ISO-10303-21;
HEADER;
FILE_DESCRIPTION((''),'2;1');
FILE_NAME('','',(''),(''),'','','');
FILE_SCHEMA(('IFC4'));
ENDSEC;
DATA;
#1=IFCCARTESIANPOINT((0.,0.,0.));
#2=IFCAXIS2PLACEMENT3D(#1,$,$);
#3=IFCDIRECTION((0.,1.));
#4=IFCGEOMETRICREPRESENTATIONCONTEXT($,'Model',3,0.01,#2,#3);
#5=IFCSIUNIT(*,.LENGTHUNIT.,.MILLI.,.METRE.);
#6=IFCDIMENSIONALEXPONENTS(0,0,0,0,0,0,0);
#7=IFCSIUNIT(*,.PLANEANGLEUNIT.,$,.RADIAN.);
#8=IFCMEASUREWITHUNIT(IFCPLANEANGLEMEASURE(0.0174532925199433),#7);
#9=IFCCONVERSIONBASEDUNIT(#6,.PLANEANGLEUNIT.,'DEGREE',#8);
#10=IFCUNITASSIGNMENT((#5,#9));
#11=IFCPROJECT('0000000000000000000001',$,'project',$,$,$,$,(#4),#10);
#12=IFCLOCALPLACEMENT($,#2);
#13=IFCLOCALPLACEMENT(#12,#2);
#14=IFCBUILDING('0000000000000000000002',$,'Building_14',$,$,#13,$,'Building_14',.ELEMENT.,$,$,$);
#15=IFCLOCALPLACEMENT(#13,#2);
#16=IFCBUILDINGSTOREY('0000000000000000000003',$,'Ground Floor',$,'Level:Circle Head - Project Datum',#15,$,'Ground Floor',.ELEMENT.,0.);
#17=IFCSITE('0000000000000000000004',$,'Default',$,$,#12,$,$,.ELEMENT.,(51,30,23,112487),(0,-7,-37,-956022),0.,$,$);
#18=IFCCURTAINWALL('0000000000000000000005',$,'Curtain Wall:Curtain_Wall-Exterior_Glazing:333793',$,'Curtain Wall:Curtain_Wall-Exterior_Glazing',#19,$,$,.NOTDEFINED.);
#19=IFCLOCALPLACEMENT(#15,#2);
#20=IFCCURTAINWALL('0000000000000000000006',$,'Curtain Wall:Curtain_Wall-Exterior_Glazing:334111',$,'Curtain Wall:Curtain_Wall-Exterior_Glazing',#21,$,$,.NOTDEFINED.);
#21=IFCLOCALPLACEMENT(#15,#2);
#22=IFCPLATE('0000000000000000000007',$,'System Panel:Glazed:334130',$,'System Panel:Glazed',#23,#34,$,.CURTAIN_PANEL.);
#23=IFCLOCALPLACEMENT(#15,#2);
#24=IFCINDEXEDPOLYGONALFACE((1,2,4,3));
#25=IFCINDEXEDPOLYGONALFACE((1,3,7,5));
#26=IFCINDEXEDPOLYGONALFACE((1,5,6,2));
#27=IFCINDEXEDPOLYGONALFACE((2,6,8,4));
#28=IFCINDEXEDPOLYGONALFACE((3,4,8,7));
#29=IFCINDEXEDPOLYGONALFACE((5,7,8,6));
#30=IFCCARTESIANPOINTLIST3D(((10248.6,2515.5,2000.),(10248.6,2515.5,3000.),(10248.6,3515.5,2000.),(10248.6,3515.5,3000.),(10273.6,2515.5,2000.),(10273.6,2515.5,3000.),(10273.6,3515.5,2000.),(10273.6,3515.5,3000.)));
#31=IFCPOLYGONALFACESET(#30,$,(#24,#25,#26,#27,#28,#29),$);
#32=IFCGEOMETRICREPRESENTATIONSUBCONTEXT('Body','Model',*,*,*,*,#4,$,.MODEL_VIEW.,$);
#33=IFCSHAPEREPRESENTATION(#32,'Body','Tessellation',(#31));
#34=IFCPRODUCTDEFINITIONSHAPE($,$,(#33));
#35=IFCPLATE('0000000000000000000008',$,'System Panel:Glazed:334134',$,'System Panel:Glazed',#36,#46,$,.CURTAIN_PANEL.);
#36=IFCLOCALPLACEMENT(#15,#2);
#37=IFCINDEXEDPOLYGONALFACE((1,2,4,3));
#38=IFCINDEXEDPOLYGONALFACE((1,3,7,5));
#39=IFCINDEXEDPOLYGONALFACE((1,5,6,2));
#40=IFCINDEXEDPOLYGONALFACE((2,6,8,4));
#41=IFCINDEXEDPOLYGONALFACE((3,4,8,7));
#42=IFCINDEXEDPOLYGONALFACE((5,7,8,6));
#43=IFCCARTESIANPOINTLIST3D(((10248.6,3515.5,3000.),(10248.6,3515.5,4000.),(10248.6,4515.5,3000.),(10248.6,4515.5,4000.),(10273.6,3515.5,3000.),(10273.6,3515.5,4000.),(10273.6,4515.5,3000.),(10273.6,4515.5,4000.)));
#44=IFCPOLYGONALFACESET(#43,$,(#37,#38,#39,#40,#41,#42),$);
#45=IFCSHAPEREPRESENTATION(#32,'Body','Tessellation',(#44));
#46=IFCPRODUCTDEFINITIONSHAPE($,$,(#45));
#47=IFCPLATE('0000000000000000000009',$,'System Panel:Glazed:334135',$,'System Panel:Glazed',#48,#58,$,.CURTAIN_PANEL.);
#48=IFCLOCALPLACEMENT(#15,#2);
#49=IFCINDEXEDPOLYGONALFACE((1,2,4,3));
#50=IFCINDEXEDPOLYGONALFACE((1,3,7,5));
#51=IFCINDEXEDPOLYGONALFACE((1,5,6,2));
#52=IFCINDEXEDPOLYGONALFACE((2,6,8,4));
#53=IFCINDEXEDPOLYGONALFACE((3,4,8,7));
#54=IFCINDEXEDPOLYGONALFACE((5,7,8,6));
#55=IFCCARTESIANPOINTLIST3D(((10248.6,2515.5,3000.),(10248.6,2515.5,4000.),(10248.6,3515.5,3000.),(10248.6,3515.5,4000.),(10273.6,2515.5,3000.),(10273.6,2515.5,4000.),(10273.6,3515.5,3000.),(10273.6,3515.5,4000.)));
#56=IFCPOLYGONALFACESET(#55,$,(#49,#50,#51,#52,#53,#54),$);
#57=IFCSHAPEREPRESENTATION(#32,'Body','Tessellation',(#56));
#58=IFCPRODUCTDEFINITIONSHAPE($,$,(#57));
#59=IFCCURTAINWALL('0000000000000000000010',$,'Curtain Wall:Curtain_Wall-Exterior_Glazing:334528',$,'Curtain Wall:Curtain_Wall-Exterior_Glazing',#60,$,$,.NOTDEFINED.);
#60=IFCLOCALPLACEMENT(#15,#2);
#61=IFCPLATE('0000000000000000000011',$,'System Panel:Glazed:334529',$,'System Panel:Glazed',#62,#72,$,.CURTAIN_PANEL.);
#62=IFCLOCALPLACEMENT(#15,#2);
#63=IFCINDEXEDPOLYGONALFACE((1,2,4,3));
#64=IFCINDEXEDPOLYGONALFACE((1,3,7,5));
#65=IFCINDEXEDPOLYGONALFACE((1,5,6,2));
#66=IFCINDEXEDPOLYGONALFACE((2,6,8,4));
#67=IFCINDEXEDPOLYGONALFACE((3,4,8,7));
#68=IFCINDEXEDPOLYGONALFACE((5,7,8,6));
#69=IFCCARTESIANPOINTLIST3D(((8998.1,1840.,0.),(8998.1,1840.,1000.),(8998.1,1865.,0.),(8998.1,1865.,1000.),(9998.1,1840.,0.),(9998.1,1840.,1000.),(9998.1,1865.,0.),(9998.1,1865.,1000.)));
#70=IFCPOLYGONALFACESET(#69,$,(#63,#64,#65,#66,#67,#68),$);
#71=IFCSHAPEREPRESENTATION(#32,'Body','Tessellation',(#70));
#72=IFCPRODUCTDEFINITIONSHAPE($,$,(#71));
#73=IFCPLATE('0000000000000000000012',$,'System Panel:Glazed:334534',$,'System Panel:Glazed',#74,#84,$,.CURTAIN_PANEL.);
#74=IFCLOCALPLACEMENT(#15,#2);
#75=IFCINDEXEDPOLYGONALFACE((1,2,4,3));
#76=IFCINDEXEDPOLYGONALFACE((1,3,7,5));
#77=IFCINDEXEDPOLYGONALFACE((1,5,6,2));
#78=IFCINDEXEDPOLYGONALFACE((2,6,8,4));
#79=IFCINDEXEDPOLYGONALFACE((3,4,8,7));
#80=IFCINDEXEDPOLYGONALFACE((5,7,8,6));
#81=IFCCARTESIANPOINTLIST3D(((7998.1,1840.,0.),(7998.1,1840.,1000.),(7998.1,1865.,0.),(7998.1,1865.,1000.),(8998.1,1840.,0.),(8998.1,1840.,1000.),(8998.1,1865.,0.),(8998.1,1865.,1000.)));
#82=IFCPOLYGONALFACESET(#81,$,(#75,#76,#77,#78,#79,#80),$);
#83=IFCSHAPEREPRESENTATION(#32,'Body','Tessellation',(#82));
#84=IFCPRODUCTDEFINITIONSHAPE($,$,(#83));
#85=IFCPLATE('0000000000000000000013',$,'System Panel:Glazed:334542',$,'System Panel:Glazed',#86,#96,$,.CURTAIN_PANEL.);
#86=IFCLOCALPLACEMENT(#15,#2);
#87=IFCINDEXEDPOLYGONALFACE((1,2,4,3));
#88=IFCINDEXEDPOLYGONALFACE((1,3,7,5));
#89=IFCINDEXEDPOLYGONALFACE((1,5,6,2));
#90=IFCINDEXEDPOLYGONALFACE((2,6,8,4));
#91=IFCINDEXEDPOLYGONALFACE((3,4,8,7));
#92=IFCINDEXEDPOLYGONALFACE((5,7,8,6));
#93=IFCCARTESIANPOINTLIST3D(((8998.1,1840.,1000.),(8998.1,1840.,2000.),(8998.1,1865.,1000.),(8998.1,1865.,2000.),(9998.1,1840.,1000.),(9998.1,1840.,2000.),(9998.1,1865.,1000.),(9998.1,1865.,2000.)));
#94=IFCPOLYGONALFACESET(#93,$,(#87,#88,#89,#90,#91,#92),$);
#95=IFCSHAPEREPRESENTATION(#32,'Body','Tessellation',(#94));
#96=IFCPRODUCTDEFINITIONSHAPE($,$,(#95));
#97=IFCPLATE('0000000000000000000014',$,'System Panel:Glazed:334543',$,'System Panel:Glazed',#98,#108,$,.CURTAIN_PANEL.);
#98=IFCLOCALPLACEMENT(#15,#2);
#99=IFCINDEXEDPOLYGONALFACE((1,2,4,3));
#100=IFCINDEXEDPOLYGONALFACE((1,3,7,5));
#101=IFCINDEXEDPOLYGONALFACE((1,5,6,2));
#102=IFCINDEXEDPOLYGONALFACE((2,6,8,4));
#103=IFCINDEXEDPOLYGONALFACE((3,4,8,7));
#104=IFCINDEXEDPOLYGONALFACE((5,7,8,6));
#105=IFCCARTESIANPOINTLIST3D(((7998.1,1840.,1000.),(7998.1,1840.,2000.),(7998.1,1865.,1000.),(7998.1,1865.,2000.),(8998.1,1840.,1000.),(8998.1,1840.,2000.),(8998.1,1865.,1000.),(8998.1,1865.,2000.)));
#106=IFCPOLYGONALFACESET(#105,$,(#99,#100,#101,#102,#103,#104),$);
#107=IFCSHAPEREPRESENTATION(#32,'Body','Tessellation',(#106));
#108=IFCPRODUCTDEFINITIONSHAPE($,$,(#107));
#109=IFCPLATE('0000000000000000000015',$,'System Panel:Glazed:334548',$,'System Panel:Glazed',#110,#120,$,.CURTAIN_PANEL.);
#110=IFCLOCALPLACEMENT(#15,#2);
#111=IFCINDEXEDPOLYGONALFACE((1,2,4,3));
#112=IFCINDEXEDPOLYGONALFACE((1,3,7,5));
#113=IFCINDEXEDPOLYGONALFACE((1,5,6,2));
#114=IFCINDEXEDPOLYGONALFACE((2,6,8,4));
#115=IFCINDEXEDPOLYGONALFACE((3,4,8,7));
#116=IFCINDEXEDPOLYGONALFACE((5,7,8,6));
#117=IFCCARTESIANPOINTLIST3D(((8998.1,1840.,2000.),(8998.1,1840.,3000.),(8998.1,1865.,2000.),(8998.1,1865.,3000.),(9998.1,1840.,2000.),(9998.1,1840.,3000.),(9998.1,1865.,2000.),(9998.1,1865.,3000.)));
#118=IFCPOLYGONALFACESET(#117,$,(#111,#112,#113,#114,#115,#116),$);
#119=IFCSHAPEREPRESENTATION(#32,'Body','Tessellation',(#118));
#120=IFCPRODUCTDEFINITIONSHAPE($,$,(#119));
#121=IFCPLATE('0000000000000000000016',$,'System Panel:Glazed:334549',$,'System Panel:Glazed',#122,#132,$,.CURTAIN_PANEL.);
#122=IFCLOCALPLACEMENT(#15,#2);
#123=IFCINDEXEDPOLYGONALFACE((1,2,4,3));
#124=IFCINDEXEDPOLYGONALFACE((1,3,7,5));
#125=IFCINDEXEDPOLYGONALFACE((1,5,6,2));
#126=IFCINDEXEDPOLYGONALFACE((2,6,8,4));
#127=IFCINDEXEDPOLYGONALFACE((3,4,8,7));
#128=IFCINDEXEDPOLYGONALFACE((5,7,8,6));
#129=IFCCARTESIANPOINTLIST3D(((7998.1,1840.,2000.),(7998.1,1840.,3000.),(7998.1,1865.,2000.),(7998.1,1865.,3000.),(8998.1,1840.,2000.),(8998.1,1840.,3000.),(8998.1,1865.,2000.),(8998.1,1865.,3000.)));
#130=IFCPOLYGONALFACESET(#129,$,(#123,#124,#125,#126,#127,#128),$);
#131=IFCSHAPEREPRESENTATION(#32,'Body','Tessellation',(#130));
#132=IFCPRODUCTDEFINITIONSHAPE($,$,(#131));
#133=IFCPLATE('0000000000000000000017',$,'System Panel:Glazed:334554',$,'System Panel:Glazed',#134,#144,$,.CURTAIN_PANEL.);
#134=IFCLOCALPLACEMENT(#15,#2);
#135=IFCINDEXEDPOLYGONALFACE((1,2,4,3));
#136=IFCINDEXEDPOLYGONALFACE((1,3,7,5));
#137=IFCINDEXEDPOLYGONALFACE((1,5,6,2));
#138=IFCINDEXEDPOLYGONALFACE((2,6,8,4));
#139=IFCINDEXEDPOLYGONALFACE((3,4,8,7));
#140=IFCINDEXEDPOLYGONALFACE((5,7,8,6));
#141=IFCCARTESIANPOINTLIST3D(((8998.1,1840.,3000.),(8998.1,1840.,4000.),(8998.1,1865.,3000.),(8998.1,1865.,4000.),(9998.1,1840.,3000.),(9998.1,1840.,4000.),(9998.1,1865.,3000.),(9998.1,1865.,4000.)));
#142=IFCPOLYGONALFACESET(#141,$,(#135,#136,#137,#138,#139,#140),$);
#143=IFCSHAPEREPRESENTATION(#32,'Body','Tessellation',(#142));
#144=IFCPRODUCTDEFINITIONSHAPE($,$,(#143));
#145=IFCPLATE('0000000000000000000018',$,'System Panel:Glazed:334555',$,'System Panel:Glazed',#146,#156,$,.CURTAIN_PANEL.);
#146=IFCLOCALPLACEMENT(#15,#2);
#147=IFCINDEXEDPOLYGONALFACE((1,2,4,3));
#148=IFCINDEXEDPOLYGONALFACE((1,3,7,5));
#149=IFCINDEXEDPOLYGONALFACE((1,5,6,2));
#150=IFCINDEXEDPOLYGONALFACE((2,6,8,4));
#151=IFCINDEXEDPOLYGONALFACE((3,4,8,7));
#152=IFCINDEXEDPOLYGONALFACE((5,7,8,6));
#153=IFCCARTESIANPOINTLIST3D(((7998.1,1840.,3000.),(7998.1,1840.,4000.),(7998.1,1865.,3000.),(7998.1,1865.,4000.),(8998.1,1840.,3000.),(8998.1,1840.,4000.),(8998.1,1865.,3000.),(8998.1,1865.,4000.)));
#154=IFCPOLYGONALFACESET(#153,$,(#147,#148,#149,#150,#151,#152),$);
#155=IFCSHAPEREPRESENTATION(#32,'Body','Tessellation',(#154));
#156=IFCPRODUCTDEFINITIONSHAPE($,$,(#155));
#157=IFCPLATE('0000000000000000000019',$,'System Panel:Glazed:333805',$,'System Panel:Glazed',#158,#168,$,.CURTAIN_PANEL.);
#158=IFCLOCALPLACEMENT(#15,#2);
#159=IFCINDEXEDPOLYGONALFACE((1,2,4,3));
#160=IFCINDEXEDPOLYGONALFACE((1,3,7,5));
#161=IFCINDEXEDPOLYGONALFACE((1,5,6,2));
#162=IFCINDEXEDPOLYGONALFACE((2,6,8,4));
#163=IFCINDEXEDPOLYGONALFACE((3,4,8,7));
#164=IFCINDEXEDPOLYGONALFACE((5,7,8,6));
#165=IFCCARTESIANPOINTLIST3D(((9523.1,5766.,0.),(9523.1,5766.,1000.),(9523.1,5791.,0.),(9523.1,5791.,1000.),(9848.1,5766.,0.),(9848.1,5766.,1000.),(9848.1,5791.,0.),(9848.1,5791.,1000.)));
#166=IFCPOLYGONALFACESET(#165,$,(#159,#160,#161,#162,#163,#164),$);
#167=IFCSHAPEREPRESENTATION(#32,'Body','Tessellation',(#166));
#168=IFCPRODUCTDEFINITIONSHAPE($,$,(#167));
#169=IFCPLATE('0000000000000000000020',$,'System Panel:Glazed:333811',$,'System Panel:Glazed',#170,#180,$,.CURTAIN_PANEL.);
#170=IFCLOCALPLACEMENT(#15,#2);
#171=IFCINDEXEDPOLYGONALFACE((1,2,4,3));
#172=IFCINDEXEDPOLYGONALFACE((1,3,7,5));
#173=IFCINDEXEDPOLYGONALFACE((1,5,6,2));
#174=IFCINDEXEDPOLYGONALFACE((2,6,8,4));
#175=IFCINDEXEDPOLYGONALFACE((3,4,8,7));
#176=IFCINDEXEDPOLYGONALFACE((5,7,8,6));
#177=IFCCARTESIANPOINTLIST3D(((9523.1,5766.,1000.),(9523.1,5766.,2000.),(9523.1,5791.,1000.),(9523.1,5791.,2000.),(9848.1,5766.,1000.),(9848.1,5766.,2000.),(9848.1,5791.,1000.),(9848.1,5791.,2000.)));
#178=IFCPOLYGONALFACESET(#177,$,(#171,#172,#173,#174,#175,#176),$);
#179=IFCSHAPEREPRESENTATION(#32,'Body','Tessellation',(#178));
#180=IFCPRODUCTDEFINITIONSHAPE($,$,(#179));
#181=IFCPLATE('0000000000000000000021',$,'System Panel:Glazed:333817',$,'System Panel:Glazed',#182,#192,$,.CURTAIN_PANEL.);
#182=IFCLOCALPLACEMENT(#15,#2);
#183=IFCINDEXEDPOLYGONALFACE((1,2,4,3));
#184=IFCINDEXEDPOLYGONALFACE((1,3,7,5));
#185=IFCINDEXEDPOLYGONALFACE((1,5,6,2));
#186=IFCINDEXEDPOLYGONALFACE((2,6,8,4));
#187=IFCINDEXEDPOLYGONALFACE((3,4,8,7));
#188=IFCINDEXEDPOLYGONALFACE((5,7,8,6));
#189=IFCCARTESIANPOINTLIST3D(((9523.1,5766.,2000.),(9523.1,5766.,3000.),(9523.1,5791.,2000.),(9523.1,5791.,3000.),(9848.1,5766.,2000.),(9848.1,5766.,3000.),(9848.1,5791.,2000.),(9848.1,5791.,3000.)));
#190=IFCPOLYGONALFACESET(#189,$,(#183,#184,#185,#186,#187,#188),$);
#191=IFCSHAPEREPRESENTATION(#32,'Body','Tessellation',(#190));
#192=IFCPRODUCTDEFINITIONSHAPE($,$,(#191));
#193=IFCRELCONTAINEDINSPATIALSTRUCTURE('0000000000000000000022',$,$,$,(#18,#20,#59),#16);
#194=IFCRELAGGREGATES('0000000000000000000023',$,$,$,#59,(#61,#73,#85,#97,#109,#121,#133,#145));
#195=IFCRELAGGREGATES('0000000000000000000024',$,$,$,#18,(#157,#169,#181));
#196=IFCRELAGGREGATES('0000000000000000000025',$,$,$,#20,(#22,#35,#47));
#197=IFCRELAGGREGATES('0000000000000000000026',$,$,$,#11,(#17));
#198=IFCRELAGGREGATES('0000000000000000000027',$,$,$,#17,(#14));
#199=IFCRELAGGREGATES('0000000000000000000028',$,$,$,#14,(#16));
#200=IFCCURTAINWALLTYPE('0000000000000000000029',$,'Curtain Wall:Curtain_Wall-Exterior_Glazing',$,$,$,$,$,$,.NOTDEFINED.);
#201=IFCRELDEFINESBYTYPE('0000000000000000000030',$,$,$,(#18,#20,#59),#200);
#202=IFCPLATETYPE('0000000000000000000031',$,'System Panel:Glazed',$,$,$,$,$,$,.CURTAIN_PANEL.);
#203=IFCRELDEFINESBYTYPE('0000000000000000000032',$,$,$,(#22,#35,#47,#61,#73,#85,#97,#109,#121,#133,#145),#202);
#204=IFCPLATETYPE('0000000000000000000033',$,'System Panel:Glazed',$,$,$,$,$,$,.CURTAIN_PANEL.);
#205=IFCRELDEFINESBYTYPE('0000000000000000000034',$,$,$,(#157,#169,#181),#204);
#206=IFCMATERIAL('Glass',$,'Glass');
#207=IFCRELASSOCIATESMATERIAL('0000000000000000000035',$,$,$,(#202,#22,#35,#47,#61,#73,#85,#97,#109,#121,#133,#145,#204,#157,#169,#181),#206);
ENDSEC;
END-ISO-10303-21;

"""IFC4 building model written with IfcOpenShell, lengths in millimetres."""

from ifc_helpers import new_model, entity, si_unit, converted_unit, direction, frame, origin, place, context, subcontext, project, spatial, indexed_curve, outline, extrude, source, transform, mapped, material, type_object, type_shapes, element, aggregate, save


model = new_model("IFC4")

# Units and contexts
model_context = context("Model", 3, precision=0.01, world=origin(), true_north=direction((0.0, 1.0)))
body_context = subcontext(model_context, "Body", "Model", "MODEL_VIEW")
ifc_project = project(units=[si_unit("LENGTHUNIT", "METRE", prefix="MILLI"), converted_unit("PLANEANGLEUNIT", "DEGREE", entity("IfcPlaneAngleMeasure", 0.0174532925199433), si_unit("PLANEANGLEUNIT", "RADIAN"), dimensions=[0, 0, 0, 0, 0, 0, 0])], contexts=[model_context])

# Site, building, storey
site_placement = place(None, origin())
site = spatial("IfcSite", under=ifc_project, at=site_placement, Name="Default", CompositionType="ELEMENT", RefLatitude=(51, 30, 23, 112487), RefLongitude=(0, -7, -37, -956022), RefElevation=0.0)
building_placement = place(site_placement, origin())
building = spatial("IfcBuilding", under=site, at=building_placement, Name="Building_14", LongName="Building_14", CompositionType="ELEMENT")
storey_placement = place(building_placement, origin())
storey = spatial("IfcBuildingStorey", under=building, at=storey_placement, Name="Ground Floor", ObjectType="Level:Circle Head - Project Datum", LongName="Ground Floor", CompositionType="ELEMENT", Elevation=0.0)

# Curtain walls, plates
curtain_wall_type = type_object("IfcCurtainWallType", Name="Curtain Wall:Curtain_Wall-Exterior_Glazing", PredefinedType="NOTDEFINED")
curtain_wall_1_placement = place(storey_placement, origin())
curtain_wall_1 = element("IfcCurtainWall", 1, at=curtain_wall_1_placement, inside=storey, type_object=curtain_wall_type, Name="Curtain Wall:Curtain_Wall-Exterior_Glazing:333793", ObjectType="Curtain Wall:Curtain_Wall-Exterior_Glazing", PredefinedType="NOTDEFINED")
ifc_material = material(Name="Glass", Category="Glass")
plate_type_1 = type_object("IfcPlateType", Name="System Panel:Glazed", PredefinedType="CURTAIN_PANEL", material=ifc_material)
shared_shape_1 = source(origin(), body_context, "Body", "SweptSolid", [
    extrude(outline(indexed_curve([(-12.5, -500.0), (12.5, -500.0), (12.5, 500.0), (-12.5, 500.0), (-12.5, -500.0)], self_intersect=False)), frame((0.0, -37.0, 0.0), z_axis=(0.0, 0.0, 1.0), x_axis=(0.0, 1.0, 0.0)), (0.0, 0.0, 1.0), 1000.0),
])
type_shapes(plate_type_1, [shared_shape_1])
curtain_wall_2_placement = place(storey_placement, origin())
curtain_wall_2 = element("IfcCurtainWall", 2, at=curtain_wall_2_placement, inside=storey, type_object=curtain_wall_type, Name="Curtain Wall:Curtain_Wall-Exterior_Glazing:334111", ObjectType="Curtain Wall:Curtain_Wall-Exterior_Glazing", PredefinedType="NOTDEFINED")
plate_1_placement = place(curtain_wall_2_placement, frame((10298.1, 3015.5, 2000.0), z_axis=(0.0, 0.0, 1.0), x_axis=(0.0, -1.0, 0.0)))
plate_1 = element("IfcPlate", 3, at=plate_1_placement, type_object=plate_type_1, material=ifc_material, Name="System Panel:Glazed:334130", ObjectType="System Panel:Glazed", PredefinedType="CURTAIN_PANEL", context=body_context, shape_type="MappedRepresentation", body=[
    mapped(shared_shape_1, transform((0.0, 0.0, 0.0), scale=1.0)),
])
plate_2_placement = place(curtain_wall_2_placement, frame((10298.1, 4015.5, 3000.0), z_axis=(0.0, 0.0, 1.0), x_axis=(0.0, -1.0, 0.0)))
plate_2 = element("IfcPlate", 4, at=plate_2_placement, type_object=plate_type_1, material=ifc_material, Name="System Panel:Glazed:334134", ObjectType="System Panel:Glazed", PredefinedType="CURTAIN_PANEL", context=body_context, shape_type="MappedRepresentation", body=[
    mapped(shared_shape_1, transform((0.0, 0.0, 0.0), scale=1.0)),
])
plate_3_placement = place(curtain_wall_2_placement, frame((10298.1, 3015.5, 3000.0), z_axis=(0.0, 0.0, 1.0), x_axis=(0.0, -1.0, 0.0)))
plate_3 = element("IfcPlate", 5, at=plate_3_placement, type_object=plate_type_1, material=ifc_material, Name="System Panel:Glazed:334135", ObjectType="System Panel:Glazed", PredefinedType="CURTAIN_PANEL", context=body_context, shape_type="MappedRepresentation", body=[
    mapped(shared_shape_1, transform((0.0, 0.0, 0.0), scale=1.0)),
])
curtain_wall_3_placement = place(storey_placement, origin())
curtain_wall_3 = element("IfcCurtainWall", 6, at=curtain_wall_3_placement, inside=storey, type_object=curtain_wall_type, Name="Curtain Wall:Curtain_Wall-Exterior_Glazing:334528", ObjectType="Curtain Wall:Curtain_Wall-Exterior_Glazing", PredefinedType="NOTDEFINED")
plate_4_placement = place(curtain_wall_3_placement, frame((9498.1, 1815.5, 0.0), z_axis=(0.0, 0.0, 1.0), x_axis=(-1.0, 0.0, 0.0)))
plate_4 = element("IfcPlate", 7, at=plate_4_placement, type_object=plate_type_1, material=ifc_material, Name="System Panel:Glazed:334529", ObjectType="System Panel:Glazed", PredefinedType="CURTAIN_PANEL", context=body_context, shape_type="MappedRepresentation", body=[
    mapped(shared_shape_1, transform((0.0, 0.0, 0.0), scale=1.0)),
])
plate_5_placement = place(curtain_wall_3_placement, frame((8498.1, 1815.5, 0.0), z_axis=(0.0, 0.0, 1.0), x_axis=(-1.0, 0.0, 0.0)))
plate_5 = element("IfcPlate", 8, at=plate_5_placement, type_object=plate_type_1, material=ifc_material, Name="System Panel:Glazed:334534", ObjectType="System Panel:Glazed", PredefinedType="CURTAIN_PANEL", context=body_context, shape_type="MappedRepresentation", body=[
    mapped(shared_shape_1, transform((0.0, 0.0, 0.0), scale=1.0)),
])
plate_6_placement = place(curtain_wall_3_placement, frame((9498.1, 1815.5, 1000.0), z_axis=(0.0, 0.0, 1.0), x_axis=(-1.0, 0.0, 0.0)))
plate_6 = element("IfcPlate", 9, at=plate_6_placement, type_object=plate_type_1, material=ifc_material, Name="System Panel:Glazed:334542", ObjectType="System Panel:Glazed", PredefinedType="CURTAIN_PANEL", context=body_context, shape_type="MappedRepresentation", body=[
    mapped(shared_shape_1, transform((0.0, 0.0, 0.0), scale=1.0)),
])
plate_7_placement = place(curtain_wall_3_placement, frame((8498.1, 1815.5, 1000.0), z_axis=(0.0, 0.0, 1.0), x_axis=(-1.0, 0.0, 0.0)))
plate_7 = element("IfcPlate", 10, at=plate_7_placement, type_object=plate_type_1, material=ifc_material, Name="System Panel:Glazed:334543", ObjectType="System Panel:Glazed", PredefinedType="CURTAIN_PANEL", context=body_context, shape_type="MappedRepresentation", body=[
    mapped(shared_shape_1, transform((0.0, 0.0, 0.0), scale=1.0)),
])
plate_8_placement = place(curtain_wall_3_placement, frame((9498.1, 1815.5, 2000.0), z_axis=(0.0, 0.0, 1.0), x_axis=(-1.0, 0.0, 0.0)))
plate_8 = element("IfcPlate", 11, at=plate_8_placement, type_object=plate_type_1, material=ifc_material, Name="System Panel:Glazed:334548", ObjectType="System Panel:Glazed", PredefinedType="CURTAIN_PANEL", context=body_context, shape_type="MappedRepresentation", body=[
    mapped(shared_shape_1, transform((0.0, 0.0, 0.0), scale=1.0)),
])
plate_9_placement = place(curtain_wall_3_placement, frame((8498.1, 1815.5, 2000.0), z_axis=(0.0, 0.0, 1.0), x_axis=(-1.0, 0.0, 0.0)))
plate_9 = element("IfcPlate", 12, at=plate_9_placement, type_object=plate_type_1, material=ifc_material, Name="System Panel:Glazed:334549", ObjectType="System Panel:Glazed", PredefinedType="CURTAIN_PANEL", context=body_context, shape_type="MappedRepresentation", body=[
    mapped(shared_shape_1, transform((0.0, 0.0, 0.0), scale=1.0)),
])
plate_10_placement = place(curtain_wall_3_placement, frame((9498.1, 1815.5, 3000.0), z_axis=(0.0, 0.0, 1.0), x_axis=(-1.0, 0.0, 0.0)))
plate_10 = element("IfcPlate", 13, at=plate_10_placement, type_object=plate_type_1, material=ifc_material, Name="System Panel:Glazed:334554", ObjectType="System Panel:Glazed", PredefinedType="CURTAIN_PANEL", context=body_context, shape_type="MappedRepresentation", body=[
    mapped(shared_shape_1, transform((0.0, 0.0, 0.0), scale=1.0)),
])
plate_11_placement = place(curtain_wall_3_placement, frame((8498.1, 1815.5, 3000.0), z_axis=(0.0, 0.0, 1.0), x_axis=(-1.0, 0.0, 0.0)))
plate_11 = element("IfcPlate", 14, at=plate_11_placement, type_object=plate_type_1, material=ifc_material, Name="System Panel:Glazed:334555", ObjectType="System Panel:Glazed", PredefinedType="CURTAIN_PANEL", context=body_context, shape_type="MappedRepresentation", body=[
    mapped(shared_shape_1, transform((0.0, 0.0, 0.0), scale=1.0)),
])
aggregate(curtain_wall_3, [plate_4, plate_5, plate_6, plate_7, plate_8, plate_9, plate_10, plate_11])

# Plates
plate_type_2 = type_object("IfcPlateType", Name="System Panel:Glazed", PredefinedType="CURTAIN_PANEL", material=ifc_material)
shared_shape_2 = source(origin(), body_context, "Body", "SweptSolid", [
    extrude(outline(indexed_curve([(-12.5, -162.5), (12.5, -162.5), (12.5, 162.5), (-12.5, 162.5), (-12.5, -162.5)], self_intersect=False)), frame((0.0, -37.0, 0.0), z_axis=(0.0, 0.0, 1.0), x_axis=(0.0, 1.0, 0.0)), (0.0, 0.0, 1.0), 1000.0),
])
type_shapes(plate_type_2, [shared_shape_2])
plate_12_placement = place(curtain_wall_1_placement, frame((9685.6, 5815.5, 0.0)))
plate_12 = element("IfcPlate", 15, at=plate_12_placement, type_object=plate_type_2, material=ifc_material, Name="System Panel:Glazed:333805", ObjectType="System Panel:Glazed", PredefinedType="CURTAIN_PANEL", context=body_context, shape_type="MappedRepresentation", body=[
    mapped(shared_shape_2, transform((0.0, 0.0, 0.0), scale=1.0)),
])
plate_13_placement = place(curtain_wall_1_placement, frame((9685.6, 5815.5, 1000.0)))
plate_13 = element("IfcPlate", 16, at=plate_13_placement, type_object=plate_type_2, material=ifc_material, Name="System Panel:Glazed:333811", ObjectType="System Panel:Glazed", PredefinedType="CURTAIN_PANEL", context=body_context, shape_type="MappedRepresentation", body=[
    mapped(shared_shape_2, transform((0.0, 0.0, 0.0), scale=1.0)),
])
plate_14_placement = place(curtain_wall_1_placement, frame((9685.6, 5815.5, 2000.0)))
plate_14 = element("IfcPlate", 17, at=plate_14_placement, type_object=plate_type_2, material=ifc_material, Name="System Panel:Glazed:333817", ObjectType="System Panel:Glazed", PredefinedType="CURTAIN_PANEL", context=body_context, shape_type="MappedRepresentation", body=[
    mapped(shared_shape_2, transform((0.0, 0.0, 0.0), scale=1.0)),
])
aggregate(curtain_wall_1, [plate_12, plate_13, plate_14])
aggregate(curtain_wall_2, [plate_1, plate_2, plate_3])

save(model, "model.ifc")
